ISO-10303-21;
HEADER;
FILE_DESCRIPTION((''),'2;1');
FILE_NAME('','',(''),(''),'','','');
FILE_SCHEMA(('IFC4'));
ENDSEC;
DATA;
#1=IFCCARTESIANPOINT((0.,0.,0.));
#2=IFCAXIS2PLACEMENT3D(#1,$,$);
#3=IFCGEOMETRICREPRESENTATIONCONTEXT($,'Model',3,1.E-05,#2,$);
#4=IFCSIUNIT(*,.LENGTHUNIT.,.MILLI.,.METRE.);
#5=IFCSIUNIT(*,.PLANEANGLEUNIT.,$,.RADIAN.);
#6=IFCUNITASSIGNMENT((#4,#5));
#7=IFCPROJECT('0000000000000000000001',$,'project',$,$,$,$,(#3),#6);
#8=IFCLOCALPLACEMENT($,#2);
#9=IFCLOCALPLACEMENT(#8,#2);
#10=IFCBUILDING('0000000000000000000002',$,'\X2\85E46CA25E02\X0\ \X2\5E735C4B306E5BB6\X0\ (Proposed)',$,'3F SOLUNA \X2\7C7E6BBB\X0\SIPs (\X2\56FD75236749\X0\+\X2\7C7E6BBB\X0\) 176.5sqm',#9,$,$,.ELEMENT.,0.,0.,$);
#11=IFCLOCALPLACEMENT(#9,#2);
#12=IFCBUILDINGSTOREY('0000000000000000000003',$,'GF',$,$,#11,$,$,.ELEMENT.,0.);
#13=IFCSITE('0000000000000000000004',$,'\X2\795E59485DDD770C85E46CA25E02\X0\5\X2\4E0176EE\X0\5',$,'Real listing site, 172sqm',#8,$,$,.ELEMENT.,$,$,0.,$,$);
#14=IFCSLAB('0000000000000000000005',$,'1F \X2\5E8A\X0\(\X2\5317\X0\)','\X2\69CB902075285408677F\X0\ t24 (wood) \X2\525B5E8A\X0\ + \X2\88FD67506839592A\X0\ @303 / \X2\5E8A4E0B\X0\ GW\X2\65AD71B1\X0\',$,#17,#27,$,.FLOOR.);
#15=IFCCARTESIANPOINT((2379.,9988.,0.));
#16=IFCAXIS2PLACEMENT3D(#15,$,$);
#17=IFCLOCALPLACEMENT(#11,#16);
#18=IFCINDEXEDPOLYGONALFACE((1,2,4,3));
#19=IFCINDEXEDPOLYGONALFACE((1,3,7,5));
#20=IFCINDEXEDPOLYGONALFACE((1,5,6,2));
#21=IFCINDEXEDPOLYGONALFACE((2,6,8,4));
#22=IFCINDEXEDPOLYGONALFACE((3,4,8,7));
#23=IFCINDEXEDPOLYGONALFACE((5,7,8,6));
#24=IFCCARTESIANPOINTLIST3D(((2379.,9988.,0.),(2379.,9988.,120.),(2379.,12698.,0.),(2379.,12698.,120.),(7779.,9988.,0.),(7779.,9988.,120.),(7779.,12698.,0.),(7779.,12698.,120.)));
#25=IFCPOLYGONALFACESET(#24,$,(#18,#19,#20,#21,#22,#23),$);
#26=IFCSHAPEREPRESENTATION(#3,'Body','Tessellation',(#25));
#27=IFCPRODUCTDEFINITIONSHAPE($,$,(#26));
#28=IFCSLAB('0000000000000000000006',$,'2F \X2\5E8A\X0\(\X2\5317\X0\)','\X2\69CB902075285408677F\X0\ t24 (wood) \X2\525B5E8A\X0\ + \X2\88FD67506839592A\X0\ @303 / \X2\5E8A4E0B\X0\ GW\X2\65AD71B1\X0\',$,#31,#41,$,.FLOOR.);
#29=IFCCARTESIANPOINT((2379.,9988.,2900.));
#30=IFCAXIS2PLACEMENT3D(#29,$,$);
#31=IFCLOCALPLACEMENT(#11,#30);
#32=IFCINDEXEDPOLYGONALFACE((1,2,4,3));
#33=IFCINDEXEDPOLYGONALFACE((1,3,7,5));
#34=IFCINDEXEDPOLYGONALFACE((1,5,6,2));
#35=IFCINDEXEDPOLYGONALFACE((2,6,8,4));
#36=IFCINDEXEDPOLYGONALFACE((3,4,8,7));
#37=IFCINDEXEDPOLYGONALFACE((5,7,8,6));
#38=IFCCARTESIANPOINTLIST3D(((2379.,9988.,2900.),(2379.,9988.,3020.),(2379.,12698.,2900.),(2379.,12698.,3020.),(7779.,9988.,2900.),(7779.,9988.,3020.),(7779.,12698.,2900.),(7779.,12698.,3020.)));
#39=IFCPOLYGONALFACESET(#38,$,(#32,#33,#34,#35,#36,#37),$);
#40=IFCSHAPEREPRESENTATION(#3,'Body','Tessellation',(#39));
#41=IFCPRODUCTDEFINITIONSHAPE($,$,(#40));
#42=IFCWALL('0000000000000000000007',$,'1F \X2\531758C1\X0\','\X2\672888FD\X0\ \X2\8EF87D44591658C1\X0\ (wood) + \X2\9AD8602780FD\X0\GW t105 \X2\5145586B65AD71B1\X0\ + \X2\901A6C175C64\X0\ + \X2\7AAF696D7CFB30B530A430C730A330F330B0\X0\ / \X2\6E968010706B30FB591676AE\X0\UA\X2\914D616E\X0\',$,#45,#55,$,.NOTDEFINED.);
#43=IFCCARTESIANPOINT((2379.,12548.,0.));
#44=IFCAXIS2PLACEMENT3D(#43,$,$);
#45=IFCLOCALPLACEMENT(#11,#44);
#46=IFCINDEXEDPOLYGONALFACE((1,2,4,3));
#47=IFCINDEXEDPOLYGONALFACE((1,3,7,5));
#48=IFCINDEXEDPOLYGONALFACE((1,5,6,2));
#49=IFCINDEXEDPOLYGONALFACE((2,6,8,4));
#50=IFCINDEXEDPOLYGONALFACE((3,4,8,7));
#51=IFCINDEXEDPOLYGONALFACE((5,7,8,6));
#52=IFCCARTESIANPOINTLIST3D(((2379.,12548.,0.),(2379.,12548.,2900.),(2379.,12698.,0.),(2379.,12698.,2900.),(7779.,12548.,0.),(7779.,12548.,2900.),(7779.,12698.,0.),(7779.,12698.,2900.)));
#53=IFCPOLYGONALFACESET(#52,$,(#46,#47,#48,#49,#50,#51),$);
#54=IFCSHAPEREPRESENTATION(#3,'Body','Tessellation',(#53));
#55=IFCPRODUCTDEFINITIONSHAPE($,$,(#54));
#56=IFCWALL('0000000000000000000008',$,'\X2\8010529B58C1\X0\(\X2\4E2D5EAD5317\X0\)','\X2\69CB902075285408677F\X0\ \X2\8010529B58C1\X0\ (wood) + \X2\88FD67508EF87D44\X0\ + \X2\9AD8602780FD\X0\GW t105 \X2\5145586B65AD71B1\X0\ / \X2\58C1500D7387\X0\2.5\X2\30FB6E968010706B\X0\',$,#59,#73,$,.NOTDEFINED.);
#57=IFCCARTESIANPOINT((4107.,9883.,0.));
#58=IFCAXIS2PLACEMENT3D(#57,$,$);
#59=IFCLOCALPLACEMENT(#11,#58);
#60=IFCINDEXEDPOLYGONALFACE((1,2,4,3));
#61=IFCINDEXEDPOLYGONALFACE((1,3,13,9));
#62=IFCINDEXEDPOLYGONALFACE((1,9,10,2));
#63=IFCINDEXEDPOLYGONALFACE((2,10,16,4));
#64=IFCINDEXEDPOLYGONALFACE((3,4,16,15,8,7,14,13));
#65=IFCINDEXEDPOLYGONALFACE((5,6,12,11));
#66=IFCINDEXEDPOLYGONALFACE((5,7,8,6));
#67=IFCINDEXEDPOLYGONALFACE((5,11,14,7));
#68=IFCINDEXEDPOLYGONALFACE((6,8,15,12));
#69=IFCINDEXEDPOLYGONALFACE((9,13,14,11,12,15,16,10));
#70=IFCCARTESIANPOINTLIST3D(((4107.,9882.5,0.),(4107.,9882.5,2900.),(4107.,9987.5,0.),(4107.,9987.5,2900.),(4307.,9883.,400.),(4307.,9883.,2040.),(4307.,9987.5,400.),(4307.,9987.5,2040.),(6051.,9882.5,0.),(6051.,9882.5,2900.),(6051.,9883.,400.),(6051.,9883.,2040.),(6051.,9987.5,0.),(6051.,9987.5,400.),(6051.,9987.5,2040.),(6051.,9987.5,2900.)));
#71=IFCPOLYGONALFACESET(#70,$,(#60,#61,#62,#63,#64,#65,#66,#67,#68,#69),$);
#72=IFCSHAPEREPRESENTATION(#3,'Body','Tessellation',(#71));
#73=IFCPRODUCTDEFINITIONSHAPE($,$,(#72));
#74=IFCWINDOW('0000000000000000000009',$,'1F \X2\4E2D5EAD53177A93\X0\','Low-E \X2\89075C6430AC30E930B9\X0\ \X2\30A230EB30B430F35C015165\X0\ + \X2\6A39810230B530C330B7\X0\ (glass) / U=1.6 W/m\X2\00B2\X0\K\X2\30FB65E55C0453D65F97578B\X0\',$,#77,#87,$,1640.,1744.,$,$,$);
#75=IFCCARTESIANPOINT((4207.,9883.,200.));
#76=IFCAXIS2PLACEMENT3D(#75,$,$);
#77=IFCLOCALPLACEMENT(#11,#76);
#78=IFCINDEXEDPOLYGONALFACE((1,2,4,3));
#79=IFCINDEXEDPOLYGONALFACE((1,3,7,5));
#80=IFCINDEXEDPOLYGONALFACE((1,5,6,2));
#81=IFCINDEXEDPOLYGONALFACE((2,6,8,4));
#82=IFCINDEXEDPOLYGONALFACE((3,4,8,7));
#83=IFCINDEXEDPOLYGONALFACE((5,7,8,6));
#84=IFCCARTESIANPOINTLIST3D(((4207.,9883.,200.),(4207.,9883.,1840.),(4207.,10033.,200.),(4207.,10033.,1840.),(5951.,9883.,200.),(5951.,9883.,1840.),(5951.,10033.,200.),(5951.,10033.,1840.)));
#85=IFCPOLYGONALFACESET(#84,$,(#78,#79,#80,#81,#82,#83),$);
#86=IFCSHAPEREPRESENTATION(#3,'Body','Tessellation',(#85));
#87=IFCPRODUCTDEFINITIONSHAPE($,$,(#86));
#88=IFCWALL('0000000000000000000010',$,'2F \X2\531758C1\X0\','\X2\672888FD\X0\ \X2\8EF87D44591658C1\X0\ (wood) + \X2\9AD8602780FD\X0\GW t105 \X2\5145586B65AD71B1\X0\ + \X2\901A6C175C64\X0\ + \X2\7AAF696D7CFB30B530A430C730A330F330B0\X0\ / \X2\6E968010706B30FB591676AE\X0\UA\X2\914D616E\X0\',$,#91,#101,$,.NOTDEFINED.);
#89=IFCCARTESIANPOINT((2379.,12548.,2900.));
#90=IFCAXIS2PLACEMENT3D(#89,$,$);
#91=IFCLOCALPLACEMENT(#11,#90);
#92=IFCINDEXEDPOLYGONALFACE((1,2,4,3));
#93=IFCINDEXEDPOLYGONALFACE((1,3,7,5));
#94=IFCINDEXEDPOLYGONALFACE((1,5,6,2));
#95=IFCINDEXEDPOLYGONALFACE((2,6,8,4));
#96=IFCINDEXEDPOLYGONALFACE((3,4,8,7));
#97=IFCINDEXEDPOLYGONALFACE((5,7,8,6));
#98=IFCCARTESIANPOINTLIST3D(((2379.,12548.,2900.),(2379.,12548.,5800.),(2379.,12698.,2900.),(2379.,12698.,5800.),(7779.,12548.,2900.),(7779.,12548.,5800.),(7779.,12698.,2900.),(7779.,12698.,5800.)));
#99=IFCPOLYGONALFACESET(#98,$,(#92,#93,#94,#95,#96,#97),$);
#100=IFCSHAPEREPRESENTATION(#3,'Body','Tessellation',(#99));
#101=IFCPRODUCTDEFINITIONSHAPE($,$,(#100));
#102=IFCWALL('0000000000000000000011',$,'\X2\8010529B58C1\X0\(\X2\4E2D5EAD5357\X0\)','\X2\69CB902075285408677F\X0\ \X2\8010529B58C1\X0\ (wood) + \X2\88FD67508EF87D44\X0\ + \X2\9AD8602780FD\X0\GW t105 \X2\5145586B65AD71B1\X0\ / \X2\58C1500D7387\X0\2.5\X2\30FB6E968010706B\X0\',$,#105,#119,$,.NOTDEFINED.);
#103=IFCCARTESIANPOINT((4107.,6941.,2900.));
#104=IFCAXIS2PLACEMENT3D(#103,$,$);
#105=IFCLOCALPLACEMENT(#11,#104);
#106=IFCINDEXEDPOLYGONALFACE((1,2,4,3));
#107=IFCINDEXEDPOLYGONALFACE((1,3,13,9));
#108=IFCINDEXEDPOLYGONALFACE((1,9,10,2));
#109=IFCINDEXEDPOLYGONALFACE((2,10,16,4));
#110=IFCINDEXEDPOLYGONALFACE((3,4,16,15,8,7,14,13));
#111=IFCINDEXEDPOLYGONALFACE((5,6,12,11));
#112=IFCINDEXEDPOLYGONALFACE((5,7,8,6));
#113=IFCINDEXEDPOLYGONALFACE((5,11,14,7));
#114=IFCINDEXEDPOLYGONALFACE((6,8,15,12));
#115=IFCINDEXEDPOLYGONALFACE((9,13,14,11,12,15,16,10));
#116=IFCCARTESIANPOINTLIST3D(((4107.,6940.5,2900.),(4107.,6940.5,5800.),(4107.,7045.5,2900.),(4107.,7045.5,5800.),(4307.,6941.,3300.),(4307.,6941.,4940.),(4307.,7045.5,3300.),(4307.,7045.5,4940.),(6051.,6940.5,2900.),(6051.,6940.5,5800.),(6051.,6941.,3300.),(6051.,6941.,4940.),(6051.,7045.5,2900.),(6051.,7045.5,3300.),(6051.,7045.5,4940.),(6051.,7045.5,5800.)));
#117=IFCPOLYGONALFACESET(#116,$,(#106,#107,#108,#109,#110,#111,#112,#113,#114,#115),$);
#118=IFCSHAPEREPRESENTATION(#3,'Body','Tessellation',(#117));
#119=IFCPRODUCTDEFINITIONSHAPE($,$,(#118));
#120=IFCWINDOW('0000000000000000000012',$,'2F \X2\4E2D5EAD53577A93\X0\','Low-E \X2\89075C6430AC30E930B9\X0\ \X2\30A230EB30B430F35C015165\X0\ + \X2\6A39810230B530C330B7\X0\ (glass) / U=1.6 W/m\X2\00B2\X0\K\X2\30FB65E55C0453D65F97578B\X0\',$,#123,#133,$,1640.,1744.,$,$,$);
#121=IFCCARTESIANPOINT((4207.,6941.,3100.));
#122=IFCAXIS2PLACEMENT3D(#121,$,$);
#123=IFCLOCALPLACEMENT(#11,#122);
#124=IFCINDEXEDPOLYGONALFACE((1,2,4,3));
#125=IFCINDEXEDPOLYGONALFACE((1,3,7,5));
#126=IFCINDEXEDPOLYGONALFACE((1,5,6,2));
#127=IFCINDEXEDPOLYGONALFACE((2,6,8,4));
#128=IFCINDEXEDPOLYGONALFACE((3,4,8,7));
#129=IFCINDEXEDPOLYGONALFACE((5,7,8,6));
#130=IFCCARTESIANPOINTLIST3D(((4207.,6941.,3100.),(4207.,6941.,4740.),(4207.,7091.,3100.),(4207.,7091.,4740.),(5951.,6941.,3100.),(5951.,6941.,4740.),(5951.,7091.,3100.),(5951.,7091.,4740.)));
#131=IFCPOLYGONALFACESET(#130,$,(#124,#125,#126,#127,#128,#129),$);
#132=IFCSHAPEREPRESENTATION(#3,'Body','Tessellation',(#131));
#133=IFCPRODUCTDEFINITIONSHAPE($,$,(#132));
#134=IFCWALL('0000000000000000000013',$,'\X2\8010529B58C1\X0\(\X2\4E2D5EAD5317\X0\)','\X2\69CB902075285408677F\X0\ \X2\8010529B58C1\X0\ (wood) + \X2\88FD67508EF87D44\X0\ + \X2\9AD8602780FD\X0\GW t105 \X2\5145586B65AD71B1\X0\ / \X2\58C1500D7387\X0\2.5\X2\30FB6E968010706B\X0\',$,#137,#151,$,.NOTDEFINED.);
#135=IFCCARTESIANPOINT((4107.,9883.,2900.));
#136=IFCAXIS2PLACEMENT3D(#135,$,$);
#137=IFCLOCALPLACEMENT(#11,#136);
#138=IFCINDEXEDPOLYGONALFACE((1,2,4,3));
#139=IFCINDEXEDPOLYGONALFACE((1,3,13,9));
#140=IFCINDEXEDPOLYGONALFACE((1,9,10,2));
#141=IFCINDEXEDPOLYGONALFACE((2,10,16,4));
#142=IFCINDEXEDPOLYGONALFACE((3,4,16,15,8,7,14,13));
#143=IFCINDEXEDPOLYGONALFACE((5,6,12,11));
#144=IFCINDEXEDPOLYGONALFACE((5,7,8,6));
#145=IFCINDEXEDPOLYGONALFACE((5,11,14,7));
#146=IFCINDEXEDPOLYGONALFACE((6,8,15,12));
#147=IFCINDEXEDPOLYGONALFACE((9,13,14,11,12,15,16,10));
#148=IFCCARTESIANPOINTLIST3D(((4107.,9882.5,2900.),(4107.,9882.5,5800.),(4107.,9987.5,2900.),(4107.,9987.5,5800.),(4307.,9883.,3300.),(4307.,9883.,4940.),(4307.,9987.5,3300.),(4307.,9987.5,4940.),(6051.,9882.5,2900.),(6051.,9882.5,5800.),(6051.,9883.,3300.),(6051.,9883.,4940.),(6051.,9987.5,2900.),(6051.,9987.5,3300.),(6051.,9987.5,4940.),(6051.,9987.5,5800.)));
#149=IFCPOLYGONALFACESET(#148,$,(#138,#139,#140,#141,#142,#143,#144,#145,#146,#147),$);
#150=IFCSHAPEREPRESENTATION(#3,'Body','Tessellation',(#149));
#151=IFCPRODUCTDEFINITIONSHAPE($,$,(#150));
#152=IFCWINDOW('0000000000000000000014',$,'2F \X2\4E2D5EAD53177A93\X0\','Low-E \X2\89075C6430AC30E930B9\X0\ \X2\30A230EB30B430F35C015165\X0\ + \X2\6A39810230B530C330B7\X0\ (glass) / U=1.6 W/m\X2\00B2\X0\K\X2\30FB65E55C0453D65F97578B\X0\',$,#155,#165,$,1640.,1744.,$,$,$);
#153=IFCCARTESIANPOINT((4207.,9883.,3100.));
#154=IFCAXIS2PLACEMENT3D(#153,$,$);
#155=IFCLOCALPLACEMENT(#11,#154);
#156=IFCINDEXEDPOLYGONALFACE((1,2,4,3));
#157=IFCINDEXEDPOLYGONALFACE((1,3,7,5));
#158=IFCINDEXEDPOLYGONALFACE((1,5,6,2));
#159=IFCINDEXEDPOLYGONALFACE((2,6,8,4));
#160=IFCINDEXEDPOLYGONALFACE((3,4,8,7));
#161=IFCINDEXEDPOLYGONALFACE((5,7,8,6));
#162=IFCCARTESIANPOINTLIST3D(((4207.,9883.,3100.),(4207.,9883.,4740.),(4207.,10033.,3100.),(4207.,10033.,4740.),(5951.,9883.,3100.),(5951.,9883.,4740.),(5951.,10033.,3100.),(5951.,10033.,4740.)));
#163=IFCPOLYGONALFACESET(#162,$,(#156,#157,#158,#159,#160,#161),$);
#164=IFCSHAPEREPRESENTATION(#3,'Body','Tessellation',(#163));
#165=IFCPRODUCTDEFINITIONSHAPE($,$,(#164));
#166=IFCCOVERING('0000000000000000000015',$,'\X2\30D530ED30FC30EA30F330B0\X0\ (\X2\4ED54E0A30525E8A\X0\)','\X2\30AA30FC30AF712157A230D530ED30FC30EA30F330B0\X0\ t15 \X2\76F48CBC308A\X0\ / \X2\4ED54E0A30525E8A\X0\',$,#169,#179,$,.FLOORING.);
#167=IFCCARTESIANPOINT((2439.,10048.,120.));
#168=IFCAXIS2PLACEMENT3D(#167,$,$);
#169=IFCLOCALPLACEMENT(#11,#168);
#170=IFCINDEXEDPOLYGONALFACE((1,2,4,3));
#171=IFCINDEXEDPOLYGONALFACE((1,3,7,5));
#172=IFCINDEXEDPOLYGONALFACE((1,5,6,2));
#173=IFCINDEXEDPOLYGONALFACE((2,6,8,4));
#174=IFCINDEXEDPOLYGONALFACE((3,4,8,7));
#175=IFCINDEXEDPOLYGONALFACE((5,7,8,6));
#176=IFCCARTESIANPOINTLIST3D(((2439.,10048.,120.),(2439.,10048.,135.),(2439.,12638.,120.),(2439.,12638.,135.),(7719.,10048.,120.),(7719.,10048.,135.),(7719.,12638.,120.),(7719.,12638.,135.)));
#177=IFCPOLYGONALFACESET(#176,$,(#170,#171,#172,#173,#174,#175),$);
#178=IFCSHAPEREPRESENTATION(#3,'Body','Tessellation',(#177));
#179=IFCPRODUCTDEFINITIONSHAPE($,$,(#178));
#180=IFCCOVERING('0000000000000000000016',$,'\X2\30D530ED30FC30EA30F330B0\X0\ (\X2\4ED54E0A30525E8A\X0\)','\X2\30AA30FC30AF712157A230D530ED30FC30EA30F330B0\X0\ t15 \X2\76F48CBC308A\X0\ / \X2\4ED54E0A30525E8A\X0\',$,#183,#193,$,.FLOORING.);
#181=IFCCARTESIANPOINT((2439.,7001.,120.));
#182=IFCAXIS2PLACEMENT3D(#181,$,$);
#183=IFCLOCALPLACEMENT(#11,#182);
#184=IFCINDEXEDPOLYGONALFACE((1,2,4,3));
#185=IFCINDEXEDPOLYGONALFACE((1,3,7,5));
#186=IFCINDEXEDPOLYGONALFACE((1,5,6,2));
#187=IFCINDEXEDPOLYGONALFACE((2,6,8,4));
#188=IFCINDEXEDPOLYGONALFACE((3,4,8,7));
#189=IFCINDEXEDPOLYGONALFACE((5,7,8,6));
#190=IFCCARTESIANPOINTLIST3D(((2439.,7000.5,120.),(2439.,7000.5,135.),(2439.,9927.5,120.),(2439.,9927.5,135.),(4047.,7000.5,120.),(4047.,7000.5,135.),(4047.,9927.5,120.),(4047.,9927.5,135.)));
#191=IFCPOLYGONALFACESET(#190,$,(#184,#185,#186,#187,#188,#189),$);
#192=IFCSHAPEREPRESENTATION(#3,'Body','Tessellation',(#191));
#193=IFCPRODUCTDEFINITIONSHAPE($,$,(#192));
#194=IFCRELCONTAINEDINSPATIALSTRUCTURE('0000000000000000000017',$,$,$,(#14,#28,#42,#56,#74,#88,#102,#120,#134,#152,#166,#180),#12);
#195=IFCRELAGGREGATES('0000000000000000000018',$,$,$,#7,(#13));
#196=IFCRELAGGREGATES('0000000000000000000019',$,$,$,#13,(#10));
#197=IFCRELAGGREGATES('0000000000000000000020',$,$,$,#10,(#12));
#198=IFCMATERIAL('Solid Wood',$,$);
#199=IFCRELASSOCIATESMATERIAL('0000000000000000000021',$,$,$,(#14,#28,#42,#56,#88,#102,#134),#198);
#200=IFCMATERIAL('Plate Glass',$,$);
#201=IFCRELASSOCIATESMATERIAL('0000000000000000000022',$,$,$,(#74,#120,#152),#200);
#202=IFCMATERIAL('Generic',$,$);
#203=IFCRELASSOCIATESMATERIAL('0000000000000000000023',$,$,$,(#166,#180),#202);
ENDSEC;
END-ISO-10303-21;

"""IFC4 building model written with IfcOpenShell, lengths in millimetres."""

from ifc_helpers import new_model, si_unit, frame, frame_2d, origin, place, context, project, spatial, rectangle, extrude, material, element, fill, save


model = new_model("IFC4")

# Units and contexts
model_context = context("Model", 3, precision=1e-05, world=origin())
ifc_project = project(units=[si_unit("LENGTHUNIT", "METRE", prefix="MILLI"), si_unit("PLANEANGLEUNIT", "RADIAN")], contexts=[model_context])

# Site, building, storey
site_placement = place(None, origin())
site = spatial("IfcSite", under=ifc_project, at=site_placement, Name="神奈川県藤沢市5丁目5", ObjectType="Real listing site, 172sqm", CompositionType="ELEMENT", RefElevation=0.0)
building_placement = place(site_placement, origin())
building = spatial("IfcBuilding", under=site, at=building_placement, Name="藤沢市 平屋の家 (Proposed)", ObjectType="3F SOLUNA 籾殻SIPs (国産杉+籾殻) 176.5sqm", CompositionType="ELEMENT", ElevationOfRefHeight=0.0, ElevationOfTerrain=0.0)
storey_placement = place(building_placement, origin())
storey = spatial("IfcBuildingStorey", under=building, at=storey_placement, Name="GF", CompositionType="ELEMENT", Elevation=0.0)

# Slabs
ifc_material_1 = material(Name="Solid Wood")
slab_1_placement = place(storey_placement, frame((2379.0, 9988.0, 0.0)))
element("IfcSlab", 1, at=slab_1_placement, inside=storey, material=ifc_material_1, Name="1F 床(北)", Description="構造用合板 t24 (wood) 剛床 + 製材根太 @303 / 床下 GW断熱", PredefinedType="FLOOR", context=model_context, shape_type="SweptSolid", body=[
    extrude(rectangle(XDim=5400.0, YDim=2710.0, at=frame_2d((2700.0, 1355.0))), frame((2379.0, 9988.0, 0.0)), (0.0, 0.0, 1.0), 120.0),
])
slab_2_placement = place(storey_placement, frame((2379.0, 9988.0, 2900.0)))
element("IfcSlab", 2, at=slab_2_placement, inside=storey, material=ifc_material_1, Name="2F 床(北)", Description="構造用合板 t24 (wood) 剛床 + 製材根太 @303 / 床下 GW断熱", PredefinedType="FLOOR", context=model_context, shape_type="SweptSolid", body=[
    extrude(rectangle(XDim=5400.0, YDim=2710.0, at=frame_2d((2700.0, 1355.0))), frame((2379.0, 9988.0, 2900.0)), (0.0, 0.0, 1.0), 120.0),
])

# Wall
wall_1_placement = place(storey_placement, frame((2379.0, 12548.0, 0.0)))
element("IfcWall", 3, at=wall_1_placement, inside=storey, material=ifc_material_1, Name="1F 北壁", Description="木製 軸組外壁 (wood) + 高性能GW t105 充填断熱 + 通気層 + 窯業系サイディング / 準耐火・外皮UA配慮", PredefinedType="NOTDEFINED", context=model_context, shape_type="SweptSolid", body=[
    extrude(rectangle(XDim=5400.0, YDim=150.0, at=frame_2d((2700.0, 75.0))), frame((2379.0, 12548.0, 0.0)), (0.0, 0.0, 1.0), 2900.0),
])

# Wall, opening, window
wall_2_placement = place(storey_placement, frame((4107.0, 9883.0, 0.0)))
wall_2 = element("IfcWall", 4, at=wall_2_placement, inside=storey, material=ifc_material_1, Name="耐力壁(中庭北)", Description="構造用合板 耐力壁 (wood) + 製材軸組 + 高性能GW t105 充填断熱 / 壁倍率2.5・準耐火", PredefinedType="NOTDEFINED", context=model_context, shape_type="SweptSolid", body=[
    extrude(rectangle(XDim=1944.0, YDim=105.0, at=frame_2d((972.0, 52.0))), frame((4107.0, 9883.0, 0.0)), (0.0, 0.0, 1.0), 2900.0),
])
opening_1_placement = place(storey_placement, frame((4207.0, 9883.0, 200.0)))
opening_1 = element("IfcOpeningElement", 5, at=opening_1_placement, cuts=wall_2, PredefinedType="NOTDEFINED", context=model_context, shape_type="SweptSolid", body=[
    extrude(rectangle(XDim=1744.0, YDim=150.0, at=frame_2d((872.0, 75.0))), frame((4207.0, 9883.0, 200.0)), (0.0, 0.0, 1.0), 1640.0),
])
ifc_material_2 = material(Name="Plate Glass")
window_1_placement = place(storey_placement, frame((4207.0, 9883.0, 200.0)))
window_1 = element("IfcWindow", 6, at=window_1_placement, inside=storey, material=ifc_material_2, Name="1F 中庭北窓", Description="Low-E 複層ガラス アルゴン封入 + 樹脂サッシ (glass) / U=1.6 W/m²K・日射取得型", OverallHeight=1640.0, OverallWidth=1744.0, context=model_context, shape_type="SweptSolid", body=[
    extrude(rectangle(XDim=1744.0, YDim=150.0, at=frame_2d((872.0, 75.0))), frame((4207.0, 9883.0, 200.0)), (0.0, 0.0, 1.0), 1640.0),
])
fill(opening_1, window_1)

# Wall
wall_3_placement = place(storey_placement, frame((2379.0, 12548.0, 2900.0)))
element("IfcWall", 7, at=wall_3_placement, inside=storey, material=ifc_material_1, Name="2F 北壁", Description="木製 軸組外壁 (wood) + 高性能GW t105 充填断熱 + 通気層 + 窯業系サイディング / 準耐火・外皮UA配慮", PredefinedType="NOTDEFINED", context=model_context, shape_type="SweptSolid", body=[
    extrude(rectangle(XDim=5400.0, YDim=150.0, at=frame_2d((2700.0, 75.0))), frame((2379.0, 12548.0, 2900.0)), (0.0, 0.0, 1.0), 2900.0),
])

# Walls, openings, windows
wall_4_placement = place(storey_placement, frame((4107.0, 6941.0, 2900.0)))
wall_4 = element("IfcWall", 8, at=wall_4_placement, inside=storey, material=ifc_material_1, Name="耐力壁(中庭南)", Description="構造用合板 耐力壁 (wood) + 製材軸組 + 高性能GW t105 充填断熱 / 壁倍率2.5・準耐火", PredefinedType="NOTDEFINED", context=model_context, shape_type="SweptSolid", body=[
    extrude(rectangle(XDim=1944.0, YDim=105.0, at=frame_2d((972.0, 52.0))), frame((4107.0, 6941.0, 2900.0)), (0.0, 0.0, 1.0), 2900.0),
])
opening_2_placement = place(storey_placement, frame((4207.0, 6941.0, 3100.0)))
opening_2 = element("IfcOpeningElement", 9, at=opening_2_placement, cuts=wall_4, PredefinedType="NOTDEFINED", context=model_context, shape_type="SweptSolid", body=[
    extrude(rectangle(XDim=1744.0, YDim=150.0, at=frame_2d((872.0, 75.0))), frame((4207.0, 6941.0, 3100.0)), (0.0, 0.0, 1.0), 1640.0),
])
window_2_placement = place(storey_placement, frame((4207.0, 6941.0, 3100.0)))
window_2 = element("IfcWindow", 10, at=window_2_placement, inside=storey, material=ifc_material_2, Name="2F 中庭南窓", Description="Low-E 複層ガラス アルゴン封入 + 樹脂サッシ (glass) / U=1.6 W/m²K・日射取得型", OverallHeight=1640.0, OverallWidth=1744.0, context=model_context, shape_type="SweptSolid", body=[
    extrude(rectangle(XDim=1744.0, YDim=150.0, at=frame_2d((872.0, 75.0))), frame((4207.0, 6941.0, 3100.0)), (0.0, 0.0, 1.0), 1640.0),
])
fill(opening_2, window_2)
wall_5_placement = place(storey_placement, frame((4107.0, 9883.0, 2900.0)))
wall_5 = element("IfcWall", 11, at=wall_5_placement, inside=storey, material=ifc_material_1, Name="耐力壁(中庭北)", Description="構造用合板 耐力壁 (wood) + 製材軸組 + 高性能GW t105 充填断熱 / 壁倍率2.5・準耐火", PredefinedType="NOTDEFINED", context=model_context, shape_type="SweptSolid", body=[
    extrude(rectangle(XDim=1944.0, YDim=105.0, at=frame_2d((972.0, 52.0))), frame((4107.0, 9883.0, 2900.0)), (0.0, 0.0, 1.0), 2900.0),
])
opening_3_placement = place(storey_placement, frame((4207.0, 9883.0, 3100.0)))
opening_3 = element("IfcOpeningElement", 12, at=opening_3_placement, cuts=wall_5, PredefinedType="NOTDEFINED", context=model_context, shape_type="SweptSolid", body=[
    extrude(rectangle(XDim=1744.0, YDim=150.0, at=frame_2d((872.0, 75.0))), frame((4207.0, 9883.0, 3100.0)), (0.0, 0.0, 1.0), 1640.0),
])
window_3_placement = place(storey_placement, frame((4207.0, 9883.0, 3100.0)))
window_3 = element("IfcWindow", 13, at=window_3_placement, inside=storey, material=ifc_material_2, Name="2F 中庭北窓", Description="Low-E 複層ガラス アルゴン封入 + 樹脂サッシ (glass) / U=1.6 W/m²K・日射取得型", OverallHeight=1640.0, OverallWidth=1744.0, context=model_context, shape_type="SweptSolid", body=[
    extrude(rectangle(XDim=1744.0, YDim=150.0, at=frame_2d((872.0, 75.0))), frame((4207.0, 9883.0, 3100.0)), (0.0, 0.0, 1.0), 1640.0),
])
fill(opening_3, window_3)

# Coverings
ifc_material_3 = material(Name="Generic")
covering_1_placement = place(storey_placement, frame((2439.0, 10048.0, 120.0)))
element("IfcCovering", 14, at=covering_1_placement, inside=storey, material=ifc_material_3, Name="フローリング (仕上げ床)", Description="オーク無垢フローリング t15 直貼り / 仕上げ床", PredefinedType="FLOORING", context=model_context, shape_type="SweptSolid", body=[
    extrude(rectangle(XDim=5280.0, YDim=2590.0, at=frame_2d((2640.0, 1295.0))), frame((2439.0, 10048.0, 120.0)), (0.0, 0.0, 1.0), 15.0),
])
covering_2_placement = place(storey_placement, frame((2439.0, 7001.0, 120.0)))
element("IfcCovering", 15, at=covering_2_placement, inside=storey, material=ifc_material_3, Name="フローリング (仕上げ床)", Description="オーク無垢フローリング t15 直貼り / 仕上げ床", PredefinedType="FLOORING", context=model_context, shape_type="SweptSolid", body=[
    extrude(rectangle(XDim=1608.0, YDim=2927.0, at=frame_2d((804.0, 1463.0))), frame((2439.0, 7001.0, 120.0)), (0.0, 0.0, 1.0), 15.0),
])

save(model, "model.ifc")
